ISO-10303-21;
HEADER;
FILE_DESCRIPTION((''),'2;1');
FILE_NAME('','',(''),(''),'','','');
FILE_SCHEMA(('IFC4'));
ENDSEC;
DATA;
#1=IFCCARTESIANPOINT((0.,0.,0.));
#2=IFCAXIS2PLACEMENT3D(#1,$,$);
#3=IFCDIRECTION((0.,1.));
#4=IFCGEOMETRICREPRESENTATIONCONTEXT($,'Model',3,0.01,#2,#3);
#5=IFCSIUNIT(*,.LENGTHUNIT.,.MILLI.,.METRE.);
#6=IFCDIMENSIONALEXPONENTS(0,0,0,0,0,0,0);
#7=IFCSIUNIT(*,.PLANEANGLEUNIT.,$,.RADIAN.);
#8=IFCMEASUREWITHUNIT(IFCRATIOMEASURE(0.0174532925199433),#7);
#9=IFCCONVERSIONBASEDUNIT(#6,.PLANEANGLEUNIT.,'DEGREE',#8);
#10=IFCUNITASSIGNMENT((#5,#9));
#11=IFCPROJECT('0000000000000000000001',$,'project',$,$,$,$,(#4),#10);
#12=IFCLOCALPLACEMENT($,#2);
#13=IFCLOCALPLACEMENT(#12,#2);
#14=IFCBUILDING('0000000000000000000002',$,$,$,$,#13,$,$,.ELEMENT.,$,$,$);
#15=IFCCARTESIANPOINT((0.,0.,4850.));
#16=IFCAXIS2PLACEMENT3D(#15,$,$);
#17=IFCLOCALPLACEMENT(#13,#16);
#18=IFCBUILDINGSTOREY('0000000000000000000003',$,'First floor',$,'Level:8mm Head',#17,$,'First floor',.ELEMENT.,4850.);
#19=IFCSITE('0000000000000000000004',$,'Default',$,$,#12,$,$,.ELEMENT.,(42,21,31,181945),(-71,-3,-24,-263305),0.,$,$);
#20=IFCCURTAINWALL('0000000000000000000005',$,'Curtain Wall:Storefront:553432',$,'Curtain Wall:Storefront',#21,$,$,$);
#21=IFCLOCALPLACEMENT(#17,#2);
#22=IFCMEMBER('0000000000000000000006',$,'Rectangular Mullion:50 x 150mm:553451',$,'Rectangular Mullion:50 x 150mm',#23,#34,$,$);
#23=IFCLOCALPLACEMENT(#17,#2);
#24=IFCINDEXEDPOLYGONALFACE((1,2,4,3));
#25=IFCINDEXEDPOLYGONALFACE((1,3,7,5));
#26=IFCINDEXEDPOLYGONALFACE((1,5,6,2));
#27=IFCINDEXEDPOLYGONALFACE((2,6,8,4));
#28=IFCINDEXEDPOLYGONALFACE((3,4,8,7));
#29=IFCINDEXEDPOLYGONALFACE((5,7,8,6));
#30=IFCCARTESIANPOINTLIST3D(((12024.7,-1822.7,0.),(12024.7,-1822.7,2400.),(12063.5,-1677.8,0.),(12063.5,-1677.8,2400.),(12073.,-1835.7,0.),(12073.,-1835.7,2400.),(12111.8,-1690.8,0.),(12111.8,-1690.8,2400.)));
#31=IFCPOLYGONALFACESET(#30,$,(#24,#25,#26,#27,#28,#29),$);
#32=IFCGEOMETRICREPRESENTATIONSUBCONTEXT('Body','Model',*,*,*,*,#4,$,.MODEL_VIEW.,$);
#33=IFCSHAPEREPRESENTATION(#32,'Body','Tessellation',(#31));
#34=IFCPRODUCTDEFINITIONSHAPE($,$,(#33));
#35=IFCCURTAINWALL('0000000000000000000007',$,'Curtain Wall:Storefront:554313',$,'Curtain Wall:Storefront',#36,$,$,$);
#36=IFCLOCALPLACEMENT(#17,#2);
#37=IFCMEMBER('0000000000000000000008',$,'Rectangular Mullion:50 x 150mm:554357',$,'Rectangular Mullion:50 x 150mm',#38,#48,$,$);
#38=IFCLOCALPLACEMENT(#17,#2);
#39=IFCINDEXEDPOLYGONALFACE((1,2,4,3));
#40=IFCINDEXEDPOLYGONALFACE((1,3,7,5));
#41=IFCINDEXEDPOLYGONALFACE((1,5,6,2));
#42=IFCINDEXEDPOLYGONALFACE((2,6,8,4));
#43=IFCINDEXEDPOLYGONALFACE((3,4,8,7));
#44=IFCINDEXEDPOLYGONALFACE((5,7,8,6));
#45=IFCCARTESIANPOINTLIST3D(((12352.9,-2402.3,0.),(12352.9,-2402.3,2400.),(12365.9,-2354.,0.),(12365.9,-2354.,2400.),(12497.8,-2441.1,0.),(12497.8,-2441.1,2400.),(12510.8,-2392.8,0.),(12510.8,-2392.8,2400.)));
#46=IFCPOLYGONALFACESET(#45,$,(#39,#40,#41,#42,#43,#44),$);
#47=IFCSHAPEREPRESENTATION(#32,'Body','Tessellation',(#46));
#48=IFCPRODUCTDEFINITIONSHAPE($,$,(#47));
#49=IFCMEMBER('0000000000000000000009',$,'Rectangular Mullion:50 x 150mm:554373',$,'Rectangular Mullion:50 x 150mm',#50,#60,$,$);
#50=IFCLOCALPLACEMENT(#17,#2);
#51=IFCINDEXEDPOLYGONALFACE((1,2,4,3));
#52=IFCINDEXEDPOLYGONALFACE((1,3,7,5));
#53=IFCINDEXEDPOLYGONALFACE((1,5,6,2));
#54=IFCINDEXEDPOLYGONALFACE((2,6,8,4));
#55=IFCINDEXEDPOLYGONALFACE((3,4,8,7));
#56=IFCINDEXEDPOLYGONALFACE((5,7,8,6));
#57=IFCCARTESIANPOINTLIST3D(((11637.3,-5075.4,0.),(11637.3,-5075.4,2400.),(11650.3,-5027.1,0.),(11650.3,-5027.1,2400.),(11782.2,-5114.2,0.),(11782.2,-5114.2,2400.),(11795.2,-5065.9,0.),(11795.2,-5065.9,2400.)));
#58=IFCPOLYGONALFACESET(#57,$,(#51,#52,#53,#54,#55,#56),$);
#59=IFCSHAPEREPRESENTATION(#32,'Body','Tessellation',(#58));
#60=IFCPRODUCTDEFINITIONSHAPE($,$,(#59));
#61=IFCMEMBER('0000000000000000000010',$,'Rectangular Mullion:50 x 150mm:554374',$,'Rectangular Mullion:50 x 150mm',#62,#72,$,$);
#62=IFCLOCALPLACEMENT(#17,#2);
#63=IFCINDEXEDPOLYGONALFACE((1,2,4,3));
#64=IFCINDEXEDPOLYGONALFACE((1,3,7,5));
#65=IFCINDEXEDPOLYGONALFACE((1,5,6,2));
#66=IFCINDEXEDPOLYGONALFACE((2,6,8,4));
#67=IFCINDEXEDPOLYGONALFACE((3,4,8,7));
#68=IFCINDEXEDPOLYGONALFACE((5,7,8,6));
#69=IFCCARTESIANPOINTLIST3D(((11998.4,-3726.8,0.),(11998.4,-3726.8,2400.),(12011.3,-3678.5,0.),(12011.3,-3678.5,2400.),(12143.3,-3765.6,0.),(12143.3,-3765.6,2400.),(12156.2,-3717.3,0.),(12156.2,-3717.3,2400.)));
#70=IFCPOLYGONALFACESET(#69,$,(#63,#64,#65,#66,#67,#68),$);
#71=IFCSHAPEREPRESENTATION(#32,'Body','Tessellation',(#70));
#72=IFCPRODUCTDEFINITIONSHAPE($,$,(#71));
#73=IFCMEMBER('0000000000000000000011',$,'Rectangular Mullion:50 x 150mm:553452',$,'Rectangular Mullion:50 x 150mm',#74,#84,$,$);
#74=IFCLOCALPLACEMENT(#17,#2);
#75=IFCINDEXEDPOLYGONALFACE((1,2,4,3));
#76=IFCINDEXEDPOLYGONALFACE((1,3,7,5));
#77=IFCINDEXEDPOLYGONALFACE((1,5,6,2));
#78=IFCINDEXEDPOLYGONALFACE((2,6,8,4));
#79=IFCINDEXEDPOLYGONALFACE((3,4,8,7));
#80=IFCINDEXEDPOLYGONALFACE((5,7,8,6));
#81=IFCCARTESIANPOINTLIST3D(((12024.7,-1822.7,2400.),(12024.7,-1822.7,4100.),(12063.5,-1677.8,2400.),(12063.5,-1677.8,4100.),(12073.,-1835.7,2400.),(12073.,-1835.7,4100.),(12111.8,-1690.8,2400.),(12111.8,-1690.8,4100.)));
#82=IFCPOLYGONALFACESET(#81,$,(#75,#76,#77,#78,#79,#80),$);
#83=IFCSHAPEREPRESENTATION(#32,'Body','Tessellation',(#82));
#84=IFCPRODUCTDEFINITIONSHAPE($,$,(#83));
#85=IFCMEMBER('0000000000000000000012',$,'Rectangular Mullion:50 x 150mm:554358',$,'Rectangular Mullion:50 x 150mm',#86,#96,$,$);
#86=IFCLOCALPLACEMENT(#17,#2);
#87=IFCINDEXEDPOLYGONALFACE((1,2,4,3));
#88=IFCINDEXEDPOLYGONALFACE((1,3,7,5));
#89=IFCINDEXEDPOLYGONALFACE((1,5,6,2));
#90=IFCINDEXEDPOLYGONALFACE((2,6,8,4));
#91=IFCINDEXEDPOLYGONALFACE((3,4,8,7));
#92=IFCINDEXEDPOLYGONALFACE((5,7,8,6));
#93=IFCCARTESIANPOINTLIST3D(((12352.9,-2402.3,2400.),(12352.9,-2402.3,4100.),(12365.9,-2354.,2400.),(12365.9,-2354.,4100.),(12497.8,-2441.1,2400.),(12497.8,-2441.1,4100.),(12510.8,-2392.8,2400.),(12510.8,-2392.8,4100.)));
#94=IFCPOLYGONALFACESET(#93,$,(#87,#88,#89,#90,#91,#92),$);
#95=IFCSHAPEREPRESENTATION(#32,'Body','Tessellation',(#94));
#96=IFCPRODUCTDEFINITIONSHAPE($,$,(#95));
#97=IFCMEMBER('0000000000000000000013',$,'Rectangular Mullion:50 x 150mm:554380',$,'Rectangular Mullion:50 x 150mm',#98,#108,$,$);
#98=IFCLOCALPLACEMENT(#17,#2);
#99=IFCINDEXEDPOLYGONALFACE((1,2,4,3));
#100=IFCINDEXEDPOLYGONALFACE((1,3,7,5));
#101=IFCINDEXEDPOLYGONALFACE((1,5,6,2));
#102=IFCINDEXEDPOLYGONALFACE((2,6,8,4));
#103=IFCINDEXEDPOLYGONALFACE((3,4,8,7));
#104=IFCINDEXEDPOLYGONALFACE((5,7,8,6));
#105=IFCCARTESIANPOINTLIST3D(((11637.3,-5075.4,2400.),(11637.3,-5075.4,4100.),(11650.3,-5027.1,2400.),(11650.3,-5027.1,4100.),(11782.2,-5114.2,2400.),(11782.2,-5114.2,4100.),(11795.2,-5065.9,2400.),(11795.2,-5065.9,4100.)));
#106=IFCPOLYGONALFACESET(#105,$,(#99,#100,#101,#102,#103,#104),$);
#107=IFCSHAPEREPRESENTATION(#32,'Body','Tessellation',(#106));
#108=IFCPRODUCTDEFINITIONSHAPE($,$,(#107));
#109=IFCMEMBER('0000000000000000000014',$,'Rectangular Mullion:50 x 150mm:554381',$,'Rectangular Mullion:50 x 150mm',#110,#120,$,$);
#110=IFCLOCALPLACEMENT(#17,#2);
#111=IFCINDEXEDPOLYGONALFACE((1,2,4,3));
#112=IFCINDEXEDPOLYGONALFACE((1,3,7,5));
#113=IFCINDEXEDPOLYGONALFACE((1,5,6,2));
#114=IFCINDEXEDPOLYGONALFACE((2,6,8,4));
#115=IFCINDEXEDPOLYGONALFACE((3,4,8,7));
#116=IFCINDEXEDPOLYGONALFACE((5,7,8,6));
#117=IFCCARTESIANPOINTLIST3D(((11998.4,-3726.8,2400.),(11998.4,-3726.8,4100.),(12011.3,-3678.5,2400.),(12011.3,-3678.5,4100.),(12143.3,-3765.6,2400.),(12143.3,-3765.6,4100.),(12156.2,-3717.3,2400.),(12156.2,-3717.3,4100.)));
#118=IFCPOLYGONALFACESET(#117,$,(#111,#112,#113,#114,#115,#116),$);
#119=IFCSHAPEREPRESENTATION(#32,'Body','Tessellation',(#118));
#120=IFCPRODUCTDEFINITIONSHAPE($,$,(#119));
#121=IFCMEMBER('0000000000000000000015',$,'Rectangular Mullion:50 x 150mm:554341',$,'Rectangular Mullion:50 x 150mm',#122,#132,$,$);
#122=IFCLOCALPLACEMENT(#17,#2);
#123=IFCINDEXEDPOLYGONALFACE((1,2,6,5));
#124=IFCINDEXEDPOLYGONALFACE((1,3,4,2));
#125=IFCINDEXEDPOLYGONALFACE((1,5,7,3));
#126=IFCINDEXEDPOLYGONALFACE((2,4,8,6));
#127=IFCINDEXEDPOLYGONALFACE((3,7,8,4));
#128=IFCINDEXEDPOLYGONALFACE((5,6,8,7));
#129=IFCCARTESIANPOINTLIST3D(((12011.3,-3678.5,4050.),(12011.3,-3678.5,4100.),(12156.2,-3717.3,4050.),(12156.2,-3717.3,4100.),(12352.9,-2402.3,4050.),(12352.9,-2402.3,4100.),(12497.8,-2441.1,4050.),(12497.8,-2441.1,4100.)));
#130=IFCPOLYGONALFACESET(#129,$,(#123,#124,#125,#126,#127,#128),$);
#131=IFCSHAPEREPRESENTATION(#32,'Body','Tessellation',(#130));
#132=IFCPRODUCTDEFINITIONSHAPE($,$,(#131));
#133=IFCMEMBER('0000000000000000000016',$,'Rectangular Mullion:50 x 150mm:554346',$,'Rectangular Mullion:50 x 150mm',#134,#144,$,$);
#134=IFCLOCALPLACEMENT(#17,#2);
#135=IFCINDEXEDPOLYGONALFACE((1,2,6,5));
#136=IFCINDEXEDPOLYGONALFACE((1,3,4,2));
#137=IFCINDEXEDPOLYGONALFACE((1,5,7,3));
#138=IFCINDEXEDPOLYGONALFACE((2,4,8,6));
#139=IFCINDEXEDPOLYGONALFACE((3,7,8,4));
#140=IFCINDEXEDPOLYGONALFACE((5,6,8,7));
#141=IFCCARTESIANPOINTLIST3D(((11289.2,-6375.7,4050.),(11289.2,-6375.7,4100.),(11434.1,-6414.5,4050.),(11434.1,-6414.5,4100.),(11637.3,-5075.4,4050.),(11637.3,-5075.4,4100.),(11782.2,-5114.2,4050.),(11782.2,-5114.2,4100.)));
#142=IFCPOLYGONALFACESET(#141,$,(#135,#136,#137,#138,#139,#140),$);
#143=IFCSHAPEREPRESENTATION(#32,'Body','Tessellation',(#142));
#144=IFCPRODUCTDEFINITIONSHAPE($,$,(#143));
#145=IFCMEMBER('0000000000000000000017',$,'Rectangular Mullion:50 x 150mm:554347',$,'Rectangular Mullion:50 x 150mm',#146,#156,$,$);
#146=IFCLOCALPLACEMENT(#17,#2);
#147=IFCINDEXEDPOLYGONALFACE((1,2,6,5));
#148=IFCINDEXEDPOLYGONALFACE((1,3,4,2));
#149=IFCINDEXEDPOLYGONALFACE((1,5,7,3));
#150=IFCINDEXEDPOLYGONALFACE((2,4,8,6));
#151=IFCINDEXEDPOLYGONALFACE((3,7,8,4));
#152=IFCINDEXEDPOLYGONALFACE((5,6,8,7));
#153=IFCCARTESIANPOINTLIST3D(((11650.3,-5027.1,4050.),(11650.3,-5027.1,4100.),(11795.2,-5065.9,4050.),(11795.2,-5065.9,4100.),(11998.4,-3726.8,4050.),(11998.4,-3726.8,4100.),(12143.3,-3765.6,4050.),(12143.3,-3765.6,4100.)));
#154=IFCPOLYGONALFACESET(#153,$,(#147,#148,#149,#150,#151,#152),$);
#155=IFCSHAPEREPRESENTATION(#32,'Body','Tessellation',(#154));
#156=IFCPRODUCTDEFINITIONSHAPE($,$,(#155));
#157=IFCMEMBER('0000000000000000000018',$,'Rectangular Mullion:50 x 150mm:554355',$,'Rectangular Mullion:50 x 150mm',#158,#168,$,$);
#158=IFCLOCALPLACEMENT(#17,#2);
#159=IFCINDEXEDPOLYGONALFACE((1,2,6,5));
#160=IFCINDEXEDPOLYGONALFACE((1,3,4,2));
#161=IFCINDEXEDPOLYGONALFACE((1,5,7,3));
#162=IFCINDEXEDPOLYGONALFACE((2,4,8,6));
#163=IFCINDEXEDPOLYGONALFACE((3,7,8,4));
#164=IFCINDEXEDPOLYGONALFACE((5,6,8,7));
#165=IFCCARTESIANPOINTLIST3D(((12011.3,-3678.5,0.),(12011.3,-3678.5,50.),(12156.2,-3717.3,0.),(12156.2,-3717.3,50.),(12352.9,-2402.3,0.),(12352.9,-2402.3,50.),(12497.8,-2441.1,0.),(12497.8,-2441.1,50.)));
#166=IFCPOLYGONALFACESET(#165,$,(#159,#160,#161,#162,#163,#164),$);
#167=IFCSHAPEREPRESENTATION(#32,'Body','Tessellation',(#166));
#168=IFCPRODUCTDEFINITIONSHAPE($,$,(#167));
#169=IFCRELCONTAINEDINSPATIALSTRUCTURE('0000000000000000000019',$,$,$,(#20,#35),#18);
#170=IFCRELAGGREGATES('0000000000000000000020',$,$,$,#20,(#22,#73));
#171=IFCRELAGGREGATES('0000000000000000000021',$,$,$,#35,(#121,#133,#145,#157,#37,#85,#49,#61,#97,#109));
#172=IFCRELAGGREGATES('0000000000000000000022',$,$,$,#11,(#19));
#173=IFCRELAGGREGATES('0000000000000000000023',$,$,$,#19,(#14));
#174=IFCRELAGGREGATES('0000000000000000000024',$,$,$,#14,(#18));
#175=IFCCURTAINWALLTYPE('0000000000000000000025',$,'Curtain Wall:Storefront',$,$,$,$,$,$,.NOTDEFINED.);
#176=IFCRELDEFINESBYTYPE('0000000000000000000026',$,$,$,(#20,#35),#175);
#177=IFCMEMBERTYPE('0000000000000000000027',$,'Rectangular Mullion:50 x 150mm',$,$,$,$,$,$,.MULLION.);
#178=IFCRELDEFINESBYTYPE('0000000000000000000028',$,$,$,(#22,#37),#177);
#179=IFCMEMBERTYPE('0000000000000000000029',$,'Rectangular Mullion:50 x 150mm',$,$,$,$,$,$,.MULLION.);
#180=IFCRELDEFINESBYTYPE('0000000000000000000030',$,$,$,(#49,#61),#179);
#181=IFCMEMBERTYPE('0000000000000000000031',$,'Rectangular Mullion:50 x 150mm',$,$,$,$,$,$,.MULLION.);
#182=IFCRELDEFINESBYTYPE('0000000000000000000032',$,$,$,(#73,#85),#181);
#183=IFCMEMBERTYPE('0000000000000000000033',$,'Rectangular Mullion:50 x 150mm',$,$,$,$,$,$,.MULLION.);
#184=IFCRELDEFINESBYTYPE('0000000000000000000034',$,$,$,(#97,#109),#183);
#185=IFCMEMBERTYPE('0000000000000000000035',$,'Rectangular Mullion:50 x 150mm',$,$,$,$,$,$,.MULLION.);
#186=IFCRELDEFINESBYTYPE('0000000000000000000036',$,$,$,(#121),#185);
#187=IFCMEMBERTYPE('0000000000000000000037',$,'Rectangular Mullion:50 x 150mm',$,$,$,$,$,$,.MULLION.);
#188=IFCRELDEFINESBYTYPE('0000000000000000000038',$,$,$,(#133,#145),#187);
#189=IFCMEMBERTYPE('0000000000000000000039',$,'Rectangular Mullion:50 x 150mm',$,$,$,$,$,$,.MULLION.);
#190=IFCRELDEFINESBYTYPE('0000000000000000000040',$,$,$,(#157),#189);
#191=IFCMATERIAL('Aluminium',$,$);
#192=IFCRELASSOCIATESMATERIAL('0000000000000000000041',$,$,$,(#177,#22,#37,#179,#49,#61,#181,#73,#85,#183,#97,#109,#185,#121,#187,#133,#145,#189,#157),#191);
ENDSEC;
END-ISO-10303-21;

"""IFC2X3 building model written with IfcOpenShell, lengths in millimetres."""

from ifc_helpers import new_model, entity, si_unit, converted_unit, direction, frame, frame_2d, origin, origin_2d_with_axis, place, context, subcontext, project, spatial, rectangle, extrude, source, transform, mapped, material, type_object, type_shapes, element, aggregate, save


model = new_model("IFC2X3")

# Units and contexts
model_context = context("Model", 3, precision=0.01, world=origin(), true_north=direction((0.0, 1.0)))
body_context = subcontext(model_context, "Body", "Model", "MODEL_VIEW")
ifc_project = project(units=[si_unit("LENGTHUNIT", "METRE", prefix="MILLI"), converted_unit("PLANEANGLEUNIT", "DEGREE", entity("IfcRatioMeasure", 0.0174532925199433), si_unit("PLANEANGLEUNIT", "RADIAN"), dimensions=[0, 0, 0, 0, 0, 0, 0])], contexts=[model_context])

# Site, building, storey
site_placement = place(None, origin())
site = spatial("IfcSite", under=ifc_project, at=site_placement, Name="Default", CompositionType="ELEMENT", RefLatitude=(42, 21, 31, 181945), RefLongitude=(-71, -3, -24, -263305), RefElevation=0.0)
building_placement = place(site_placement, origin())
building = spatial("IfcBuilding", under=site, at=building_placement, CompositionType="ELEMENT")
storey_placement = place(building_placement, frame((0.0, 0.0, 4850.0)))
storey = spatial("IfcBuildingStorey", under=building, at=storey_placement, Name="First floor", ObjectType="Level:8mm Head", LongName="First floor", CompositionType="ELEMENT", Elevation=4850.0)

# Curtain wall, member
curtain_wall_type = type_object("IfcCurtainWallType", Name="Curtain Wall:Storefront", PredefinedType="NOTDEFINED")
curtain_wall_1_placement = place(storey_placement, frame((0.0, 0.0, -4850.0)))
curtain_wall_1 = element("IfcCurtainWall", 1, at=curtain_wall_1_placement, inside=storey, type_object=curtain_wall_type, Name="Curtain Wall:Storefront:553432", ObjectType="Curtain Wall:Storefront")
ifc_material_1 = material(Name="Aluminium")
member_type_1 = type_object("IfcMemberType", Name="Rectangular Mullion:50 x 150mm", PredefinedType="MULLION", material=ifc_material_1)
shared_shape_1 = source(origin(), body_context, "Body", "SweptSolid", [
    extrude(rectangle(XDim=150.0, YDim=50.0, at=origin_2d_with_axis()), frame((-25.0, 0.0, -2400.0), z_axis=(0.0, 0.0, 1.0), x_axis=(0.0, -1.0, 0.0)), (0.0, 0.0, 1.0), 2400.0),
])
type_shapes(member_type_1, [shared_shape_1])
member_1_placement = place(storey_placement, frame((12092.4, -1763.2, 0.0), z_axis=(0.0, 0.0, -1.0), x_axis=(0.965983, -0.258606, 0.0)))
member_1 = element("IfcMember", 2, at=member_1_placement, type_object=member_type_1, material=ifc_material_1, Name="Rectangular Mullion:50 x 150mm:553451", ObjectType="Rectangular Mullion:50 x 150mm", context=body_context, shape_type="MappedRepresentation", body=[
    mapped(shared_shape_1, transform((0.0, 0.0, 0.0), scale=1.0)),
])

# Curtain wall, members
curtain_wall_2_placement = place(storey_placement, frame((0.0, 0.0, -4850.0)))
curtain_wall_2 = element("IfcCurtainWall", 3, at=curtain_wall_2_placement, inside=storey, type_object=curtain_wall_type, Name="Curtain Wall:Storefront:554313", ObjectType="Curtain Wall:Storefront")
member_2_placement = place(storey_placement, frame((12438.3, -2373.4, 0.0), z_axis=(0.0, 0.0, -1.0), x_axis=(0.258607, 0.965983, 0.0)))
member_2 = element("IfcMember", 4, at=member_2_placement, type_object=member_type_1, material=ifc_material_1, Name="Rectangular Mullion:50 x 150mm:554357", ObjectType="Rectangular Mullion:50 x 150mm", context=body_context, shape_type="MappedRepresentation", body=[
    mapped(shared_shape_1, transform((0.0, 0.0, 0.0), scale=1.0)),
])
member_type_2 = type_object("IfcMemberType", Name="Rectangular Mullion:50 x 150mm", PredefinedType="MULLION", material=ifc_material_1)
shared_shape_2 = source(origin(), body_context, "Body", "SweptSolid", [
    extrude(rectangle(XDim=150.0, YDim=50.0, at=origin_2d_with_axis()), frame((0.0, 0.0, -2400.0), z_axis=(0.0, 0.0, 1.0), x_axis=(0.0, -1.0, 0.0)), (0.0, 0.0, 1.0), 2400.0),
])
type_shapes(member_type_2, [shared_shape_2])
member_3_placement = place(storey_placement, frame((11716.2, -5070.6, 0.0), z_axis=(0.0, 0.0, -1.0), x_axis=(0.258607, 0.965983, 0.0)))
member_3 = element("IfcMember", 5, at=member_3_placement, type_object=member_type_2, material=ifc_material_1, Name="Rectangular Mullion:50 x 150mm:554373", ObjectType="Rectangular Mullion:50 x 150mm", context=body_context, shape_type="MappedRepresentation", body=[
    mapped(shared_shape_2, transform((0.0, 0.0, 0.0), scale=1.0)),
])
member_4_placement = place(storey_placement, frame((12077.3, -3722.0, 0.0), z_axis=(0.0, 0.0, -1.0), x_axis=(0.258607, 0.965983, 0.0)))
member_4 = element("IfcMember", 6, at=member_4_placement, type_object=member_type_2, material=ifc_material_1, Name="Rectangular Mullion:50 x 150mm:554374", ObjectType="Rectangular Mullion:50 x 150mm", context=body_context, shape_type="MappedRepresentation", body=[
    mapped(shared_shape_2, transform((0.0, 0.0, 0.0), scale=1.0)),
])

# Members
member_type_3 = type_object("IfcMemberType", Name="Rectangular Mullion:50 x 150mm", PredefinedType="MULLION", material=ifc_material_1)
shared_shape_3 = source(origin(), body_context, "Body", "SweptSolid", [
    extrude(rectangle(XDim=150.0, YDim=50.0, at=origin_2d_with_axis()), frame((-25.0, 0.0, -1700.0), z_axis=(0.0, 0.0, 1.0), x_axis=(0.0, -1.0, 0.0)), (0.0, 0.0, 1.0), 1700.0),
])
type_shapes(member_type_3, [shared_shape_3])
member_5_placement = place(storey_placement, frame((12092.4, -1763.2, 2400.0), z_axis=(0.0, 0.0, -1.0), x_axis=(0.965983, -0.258606, 0.0)))
member_5 = element("IfcMember", 7, at=member_5_placement, type_object=member_type_3, material=ifc_material_1, Name="Rectangular Mullion:50 x 150mm:553452", ObjectType="Rectangular Mullion:50 x 150mm", context=body_context, shape_type="MappedRepresentation", body=[
    mapped(shared_shape_3, transform((0.0, 0.0, 0.0), scale=1.0)),
])
aggregate(curtain_wall_1, [member_1, member_5])
member_6_placement = place(storey_placement, frame((12438.3, -2373.4, 2400.0), z_axis=(0.0, 0.0, -1.0), x_axis=(0.258607, 0.965983, 0.0)))
member_6 = element("IfcMember", 8, at=member_6_placement, type_object=member_type_3, material=ifc_material_1, Name="Rectangular Mullion:50 x 150mm:554358", ObjectType="Rectangular Mullion:50 x 150mm", context=body_context, shape_type="MappedRepresentation", body=[
    mapped(shared_shape_3, transform((0.0, 0.0, 0.0), scale=1.0)),
])
member_type_4 = type_object("IfcMemberType", Name="Rectangular Mullion:50 x 150mm", PredefinedType="MULLION", material=ifc_material_1)
shared_shape_4 = source(origin(), body_context, "Body", "SweptSolid", [
    extrude(rectangle(XDim=150.0, YDim=50.0, at=origin_2d_with_axis()), frame((0.0, 0.0, -1700.0), z_axis=(0.0, 0.0, 1.0), x_axis=(0.0, -1.0, 0.0)), (0.0, 0.0, 1.0), 1700.0),
])
type_shapes(member_type_4, [shared_shape_4])
member_7_placement = place(storey_placement, frame((11716.2, -5070.6, 2400.0), z_axis=(0.0, 0.0, -1.0), x_axis=(0.258607, 0.965983, 0.0)))
member_7 = element("IfcMember", 9, at=member_7_placement, type_object=member_type_4, material=ifc_material_1, Name="Rectangular Mullion:50 x 150mm:554380", ObjectType="Rectangular Mullion:50 x 150mm", context=body_context, shape_type="MappedRepresentation", body=[
    mapped(shared_shape_4, transform((0.0, 0.0, 0.0), scale=1.0)),
])
member_8_placement = place(storey_placement, frame((12077.3, -3722.0, 2400.0), z_axis=(0.0, 0.0, -1.0), x_axis=(0.258607, 0.965983, 0.0)))
member_8 = element("IfcMember", 10, at=member_8_placement, type_object=member_type_4, material=ifc_material_1, Name="Rectangular Mullion:50 x 150mm:554381", ObjectType="Rectangular Mullion:50 x 150mm", context=body_context, shape_type="MappedRepresentation", body=[
    mapped(shared_shape_4, transform((0.0, 0.0, 0.0), scale=1.0)),
])
member_type_5 = type_object("IfcMemberType", Name="Rectangular Mullion:50 x 150mm", PredefinedType="MULLION", material=ifc_material_1)
shared_shape_5 = source(origin(), body_context, "Body", "SweptSolid", [
    extrude(rectangle(XDim=150.0, YDim=50.0, at=frame_2d((0.0, 0.0), x_axis=(1.0, 0.0))), frame((-25.0, 0.0, -1321.1), z_axis=(0.0, 0.0, 1.0), x_axis=(0.0, -1.0, 0.0)), (0.0, 0.0, 1.0), 1321.1),
])
type_shapes(member_type_5, [shared_shape_5])
member_9_placement = place(storey_placement, frame((12425.4, -2421.7, 4100.0), z_axis=(0.258607, 0.965983, 0.0), x_axis=(0.0, 0.0, 1.0)))
member_9 = element("IfcMember", 11, at=member_9_placement, type_object=member_type_5, material=ifc_material_1, Name="Rectangular Mullion:50 x 150mm:554341", ObjectType="Rectangular Mullion:50 x 150mm", context=body_context, shape_type="MappedRepresentation", body=[
    mapped(shared_shape_5, transform((0.0, 0.0, 0.0), scale=1.0)),
])
member_type_6 = type_object("IfcMemberType", Name="Rectangular Mullion:50 x 150mm", PredefinedType="MULLION", material=ifc_material_1)
shared_shape_6 = source(origin(), body_context, "Body", "SweptSolid", [
    extrude(rectangle(XDim=150.0, YDim=50.0, at=origin_2d_with_axis()), frame((-25.0, 0.0, -1346.1), z_axis=(0.0, 0.0, 1.0), x_axis=(0.0, -1.0, 0.0)), (0.0, 0.0, 1.0), 1346.1),
])
type_shapes(member_type_6, [shared_shape_6])
member_10_placement = place(storey_placement, frame((11709.8, -5094.8, 4100.0), z_axis=(0.258607, 0.965983, 0.0), x_axis=(0.0, 0.0, 1.0)))
member_10 = element("IfcMember", 12, at=member_10_placement, type_object=member_type_6, material=ifc_material_1, Name="Rectangular Mullion:50 x 150mm:554346", ObjectType="Rectangular Mullion:50 x 150mm", context=body_context, shape_type="MappedRepresentation", body=[
    mapped(shared_shape_6, transform((0.0, 0.0, 0.0), scale=1.0)),
])
member_11_placement = place(storey_placement, frame((12070.8, -3746.2, 4100.0), z_axis=(0.258607, 0.965983, 0.0), x_axis=(0.0, 0.0, 1.0)))
member_11 = element("IfcMember", 13, at=member_11_placement, type_object=member_type_6, material=ifc_material_1, Name="Rectangular Mullion:50 x 150mm:554347", ObjectType="Rectangular Mullion:50 x 150mm", context=body_context, shape_type="MappedRepresentation", body=[
    mapped(shared_shape_6, transform((0.0, 0.0, 0.0), scale=1.0)),
])
member_type_7 = type_object("IfcMemberType", Name="Rectangular Mullion:50 x 150mm", PredefinedType="MULLION", material=ifc_material_1)
shared_shape_7 = source(origin(), body_context, "Body", "SweptSolid", [
    extrude(rectangle(XDim=150.0, YDim=50.0, at=origin_2d_with_axis()), frame((-25.0, 0.0, -1321.1), z_axis=(0.0, 0.0, 1.0), x_axis=(0.0, -1.0, 0.0)), (0.0, 0.0, 1.0), 1321.1),
])
type_shapes(member_type_7, [shared_shape_7])
member_12_placement = place(storey_placement, frame((12083.7, -3697.9, 0.0), z_axis=(-0.258607, -0.965983, 0.0), x_axis=(0.0, 0.0, -1.0)))
member_12 = element("IfcMember", 14, at=member_12_placement, type_object=member_type_7, material=ifc_material_1, Name="Rectangular Mullion:50 x 150mm:554355", ObjectType="Rectangular Mullion:50 x 150mm", context=body_context, shape_type="MappedRepresentation", body=[
    mapped(shared_shape_7, transform((0.0, 0.0, 0.0), scale=1.0)),
])

aggregate(curtain_wall_2, [member_9, member_10, member_11, member_12, member_2, member_6, member_3, member_4, member_7, member_8])

save(model, "model.ifc")
